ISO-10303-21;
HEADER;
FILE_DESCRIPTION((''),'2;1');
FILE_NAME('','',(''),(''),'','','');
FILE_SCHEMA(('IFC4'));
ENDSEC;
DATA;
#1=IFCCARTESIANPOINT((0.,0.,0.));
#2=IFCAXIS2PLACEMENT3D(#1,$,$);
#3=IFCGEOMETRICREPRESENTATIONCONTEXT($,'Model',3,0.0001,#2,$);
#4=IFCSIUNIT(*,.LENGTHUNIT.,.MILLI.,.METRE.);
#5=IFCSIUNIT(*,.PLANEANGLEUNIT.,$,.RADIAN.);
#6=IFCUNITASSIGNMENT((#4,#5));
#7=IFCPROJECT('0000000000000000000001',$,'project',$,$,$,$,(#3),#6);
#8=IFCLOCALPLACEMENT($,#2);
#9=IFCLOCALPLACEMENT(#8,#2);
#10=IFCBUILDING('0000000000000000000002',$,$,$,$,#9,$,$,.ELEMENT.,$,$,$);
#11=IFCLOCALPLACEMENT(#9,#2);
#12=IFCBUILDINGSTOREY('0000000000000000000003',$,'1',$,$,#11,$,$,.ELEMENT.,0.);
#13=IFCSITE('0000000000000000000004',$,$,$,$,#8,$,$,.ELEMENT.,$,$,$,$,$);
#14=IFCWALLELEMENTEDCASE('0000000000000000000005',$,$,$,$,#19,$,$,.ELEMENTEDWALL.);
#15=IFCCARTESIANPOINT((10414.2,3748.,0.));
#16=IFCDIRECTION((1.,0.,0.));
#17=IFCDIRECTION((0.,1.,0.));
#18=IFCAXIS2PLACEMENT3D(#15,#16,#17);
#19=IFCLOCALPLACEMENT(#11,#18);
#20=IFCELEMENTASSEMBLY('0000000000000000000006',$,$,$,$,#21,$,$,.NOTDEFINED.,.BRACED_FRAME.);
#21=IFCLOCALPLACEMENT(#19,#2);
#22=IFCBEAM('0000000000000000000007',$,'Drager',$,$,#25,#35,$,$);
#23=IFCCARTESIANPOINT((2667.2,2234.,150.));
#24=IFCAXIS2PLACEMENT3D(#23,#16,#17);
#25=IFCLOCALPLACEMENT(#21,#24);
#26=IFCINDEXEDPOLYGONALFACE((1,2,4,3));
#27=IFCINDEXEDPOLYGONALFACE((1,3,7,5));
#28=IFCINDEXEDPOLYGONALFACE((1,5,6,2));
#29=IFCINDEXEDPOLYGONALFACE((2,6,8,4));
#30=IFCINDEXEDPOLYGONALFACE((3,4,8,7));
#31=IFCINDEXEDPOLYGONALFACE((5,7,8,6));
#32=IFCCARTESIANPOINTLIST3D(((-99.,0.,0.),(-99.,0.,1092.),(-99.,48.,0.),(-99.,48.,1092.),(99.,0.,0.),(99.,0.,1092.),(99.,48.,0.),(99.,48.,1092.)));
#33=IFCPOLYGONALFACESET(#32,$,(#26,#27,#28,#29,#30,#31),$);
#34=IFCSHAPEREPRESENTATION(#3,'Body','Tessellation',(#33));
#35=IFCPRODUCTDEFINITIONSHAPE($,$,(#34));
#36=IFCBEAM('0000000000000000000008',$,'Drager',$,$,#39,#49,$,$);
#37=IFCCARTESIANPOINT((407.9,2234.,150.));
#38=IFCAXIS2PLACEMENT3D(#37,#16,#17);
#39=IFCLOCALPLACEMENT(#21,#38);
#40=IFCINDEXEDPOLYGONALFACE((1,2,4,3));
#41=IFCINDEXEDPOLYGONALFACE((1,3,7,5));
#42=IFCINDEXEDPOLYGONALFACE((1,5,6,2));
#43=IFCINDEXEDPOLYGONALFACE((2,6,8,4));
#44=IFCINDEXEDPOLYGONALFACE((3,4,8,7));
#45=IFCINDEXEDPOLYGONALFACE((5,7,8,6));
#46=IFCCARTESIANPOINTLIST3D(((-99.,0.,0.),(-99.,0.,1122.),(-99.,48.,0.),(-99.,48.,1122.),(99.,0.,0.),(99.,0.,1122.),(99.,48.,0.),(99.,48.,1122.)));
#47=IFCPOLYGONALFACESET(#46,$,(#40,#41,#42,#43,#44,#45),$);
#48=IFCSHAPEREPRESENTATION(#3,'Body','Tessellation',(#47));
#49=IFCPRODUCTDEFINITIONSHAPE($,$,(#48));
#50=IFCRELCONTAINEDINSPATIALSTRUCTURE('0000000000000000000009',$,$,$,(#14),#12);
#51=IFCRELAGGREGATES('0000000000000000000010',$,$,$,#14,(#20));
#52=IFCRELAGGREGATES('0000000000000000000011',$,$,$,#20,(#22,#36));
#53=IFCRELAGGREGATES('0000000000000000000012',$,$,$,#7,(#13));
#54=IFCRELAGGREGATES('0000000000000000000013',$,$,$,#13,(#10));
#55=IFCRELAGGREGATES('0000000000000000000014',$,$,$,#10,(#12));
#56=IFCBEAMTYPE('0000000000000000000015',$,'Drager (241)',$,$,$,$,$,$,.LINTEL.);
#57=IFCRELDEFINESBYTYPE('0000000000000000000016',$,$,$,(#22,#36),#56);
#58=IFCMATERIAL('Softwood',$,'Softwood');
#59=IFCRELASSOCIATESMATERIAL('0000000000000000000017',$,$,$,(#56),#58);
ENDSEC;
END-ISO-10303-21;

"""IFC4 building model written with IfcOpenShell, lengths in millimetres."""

from ifc_helpers import new_model, si_unit, frame, origin, place, context, project, spatial, rectangle, extrude, material, material_profile, profile_set, type_object, element, aggregate, save


model = new_model("IFC4")

# Units and contexts
model_context = context("Model", 3, precision=0.0001, world=origin())
ifc_project = project(units=[si_unit("LENGTHUNIT", "METRE", prefix="MILLI"), si_unit("PLANEANGLEUNIT", "RADIAN")], contexts=[model_context])

# Site, building, storey
site_placement = place(None, origin())
site = spatial("IfcSite", under=ifc_project, at=site_placement, CompositionType="ELEMENT")
building_placement = place(site_placement, origin())
building = spatial("IfcBuilding", under=site, at=building_placement, CompositionType="ELEMENT")
storey_placement = place(building_placement, origin())
storey = spatial("IfcBuildingStorey", under=building, at=storey_placement, Name="1", CompositionType="ELEMENT", Elevation=0.0)

# Wall, element assembly
wall_1_placement = place(storey_placement, frame((10414.2, 3748.0, 0.0), z_axis=(1.0, 0.0, 0.0), x_axis=(0.0, 1.0, 0.0)))
wall_1 = element("IfcWallElementedCase", 1, at=wall_1_placement, inside=storey, PredefinedType="ELEMENTEDWALL")
assembly_1_placement = place(wall_1_placement, origin())
assembly_1 = element("IfcElementAssembly", 2, at=assembly_1_placement, AssemblyPlace="NOTDEFINED", PredefinedType="BRACED_FRAME")
aggregate(wall_1, [assembly_1])

# Beams
ifc_material_1 = material(Name="Softwood", Category="Softwood")
ifc_material_profile_1 = material_profile(ifc_material_1, rectangle(XDim=198.0, YDim=48.0), Name="Drager (241)")
ifc_profile_set_1 = profile_set([ifc_material_profile_1])
beam_type = type_object("IfcBeamType", Name="Drager (241)", PredefinedType="LINTEL", material=ifc_profile_set_1)
beam_1_placement = place(assembly_1_placement, frame((2667.2, 2234.0, 150.0), z_axis=(1.0, 0.0, 0.0), x_axis=(0.0, 1.0, 0.0)))
beam_1 = element("IfcBeam", 3, at=beam_1_placement, type_object=beam_type, Name="Drager", context=model_context, shape_type="SweptSolid", body=[
    extrude(rectangle(XDim=198.0, YDim=48.0), frame((0.0, 24.0, 0.0)), (0.0, 0.0, 1.0), 1092.0),
])
beam_2_placement = place(assembly_1_placement, frame((407.9, 2234.0, 150.0), z_axis=(1.0, 0.0, 0.0), x_axis=(0.0, 1.0, 0.0)))
beam_2 = element("IfcBeam", 4, at=beam_2_placement, type_object=beam_type, Name="Drager", context=model_context, shape_type="SweptSolid", body=[
    extrude(rectangle(XDim=198.0, YDim=48.0), frame((0.0, 24.0, 0.0)), (0.0, 0.0, 1.0), 1122.0),
])

aggregate(assembly_1, [beam_1, beam_2])

save(model, "model.ifc")
